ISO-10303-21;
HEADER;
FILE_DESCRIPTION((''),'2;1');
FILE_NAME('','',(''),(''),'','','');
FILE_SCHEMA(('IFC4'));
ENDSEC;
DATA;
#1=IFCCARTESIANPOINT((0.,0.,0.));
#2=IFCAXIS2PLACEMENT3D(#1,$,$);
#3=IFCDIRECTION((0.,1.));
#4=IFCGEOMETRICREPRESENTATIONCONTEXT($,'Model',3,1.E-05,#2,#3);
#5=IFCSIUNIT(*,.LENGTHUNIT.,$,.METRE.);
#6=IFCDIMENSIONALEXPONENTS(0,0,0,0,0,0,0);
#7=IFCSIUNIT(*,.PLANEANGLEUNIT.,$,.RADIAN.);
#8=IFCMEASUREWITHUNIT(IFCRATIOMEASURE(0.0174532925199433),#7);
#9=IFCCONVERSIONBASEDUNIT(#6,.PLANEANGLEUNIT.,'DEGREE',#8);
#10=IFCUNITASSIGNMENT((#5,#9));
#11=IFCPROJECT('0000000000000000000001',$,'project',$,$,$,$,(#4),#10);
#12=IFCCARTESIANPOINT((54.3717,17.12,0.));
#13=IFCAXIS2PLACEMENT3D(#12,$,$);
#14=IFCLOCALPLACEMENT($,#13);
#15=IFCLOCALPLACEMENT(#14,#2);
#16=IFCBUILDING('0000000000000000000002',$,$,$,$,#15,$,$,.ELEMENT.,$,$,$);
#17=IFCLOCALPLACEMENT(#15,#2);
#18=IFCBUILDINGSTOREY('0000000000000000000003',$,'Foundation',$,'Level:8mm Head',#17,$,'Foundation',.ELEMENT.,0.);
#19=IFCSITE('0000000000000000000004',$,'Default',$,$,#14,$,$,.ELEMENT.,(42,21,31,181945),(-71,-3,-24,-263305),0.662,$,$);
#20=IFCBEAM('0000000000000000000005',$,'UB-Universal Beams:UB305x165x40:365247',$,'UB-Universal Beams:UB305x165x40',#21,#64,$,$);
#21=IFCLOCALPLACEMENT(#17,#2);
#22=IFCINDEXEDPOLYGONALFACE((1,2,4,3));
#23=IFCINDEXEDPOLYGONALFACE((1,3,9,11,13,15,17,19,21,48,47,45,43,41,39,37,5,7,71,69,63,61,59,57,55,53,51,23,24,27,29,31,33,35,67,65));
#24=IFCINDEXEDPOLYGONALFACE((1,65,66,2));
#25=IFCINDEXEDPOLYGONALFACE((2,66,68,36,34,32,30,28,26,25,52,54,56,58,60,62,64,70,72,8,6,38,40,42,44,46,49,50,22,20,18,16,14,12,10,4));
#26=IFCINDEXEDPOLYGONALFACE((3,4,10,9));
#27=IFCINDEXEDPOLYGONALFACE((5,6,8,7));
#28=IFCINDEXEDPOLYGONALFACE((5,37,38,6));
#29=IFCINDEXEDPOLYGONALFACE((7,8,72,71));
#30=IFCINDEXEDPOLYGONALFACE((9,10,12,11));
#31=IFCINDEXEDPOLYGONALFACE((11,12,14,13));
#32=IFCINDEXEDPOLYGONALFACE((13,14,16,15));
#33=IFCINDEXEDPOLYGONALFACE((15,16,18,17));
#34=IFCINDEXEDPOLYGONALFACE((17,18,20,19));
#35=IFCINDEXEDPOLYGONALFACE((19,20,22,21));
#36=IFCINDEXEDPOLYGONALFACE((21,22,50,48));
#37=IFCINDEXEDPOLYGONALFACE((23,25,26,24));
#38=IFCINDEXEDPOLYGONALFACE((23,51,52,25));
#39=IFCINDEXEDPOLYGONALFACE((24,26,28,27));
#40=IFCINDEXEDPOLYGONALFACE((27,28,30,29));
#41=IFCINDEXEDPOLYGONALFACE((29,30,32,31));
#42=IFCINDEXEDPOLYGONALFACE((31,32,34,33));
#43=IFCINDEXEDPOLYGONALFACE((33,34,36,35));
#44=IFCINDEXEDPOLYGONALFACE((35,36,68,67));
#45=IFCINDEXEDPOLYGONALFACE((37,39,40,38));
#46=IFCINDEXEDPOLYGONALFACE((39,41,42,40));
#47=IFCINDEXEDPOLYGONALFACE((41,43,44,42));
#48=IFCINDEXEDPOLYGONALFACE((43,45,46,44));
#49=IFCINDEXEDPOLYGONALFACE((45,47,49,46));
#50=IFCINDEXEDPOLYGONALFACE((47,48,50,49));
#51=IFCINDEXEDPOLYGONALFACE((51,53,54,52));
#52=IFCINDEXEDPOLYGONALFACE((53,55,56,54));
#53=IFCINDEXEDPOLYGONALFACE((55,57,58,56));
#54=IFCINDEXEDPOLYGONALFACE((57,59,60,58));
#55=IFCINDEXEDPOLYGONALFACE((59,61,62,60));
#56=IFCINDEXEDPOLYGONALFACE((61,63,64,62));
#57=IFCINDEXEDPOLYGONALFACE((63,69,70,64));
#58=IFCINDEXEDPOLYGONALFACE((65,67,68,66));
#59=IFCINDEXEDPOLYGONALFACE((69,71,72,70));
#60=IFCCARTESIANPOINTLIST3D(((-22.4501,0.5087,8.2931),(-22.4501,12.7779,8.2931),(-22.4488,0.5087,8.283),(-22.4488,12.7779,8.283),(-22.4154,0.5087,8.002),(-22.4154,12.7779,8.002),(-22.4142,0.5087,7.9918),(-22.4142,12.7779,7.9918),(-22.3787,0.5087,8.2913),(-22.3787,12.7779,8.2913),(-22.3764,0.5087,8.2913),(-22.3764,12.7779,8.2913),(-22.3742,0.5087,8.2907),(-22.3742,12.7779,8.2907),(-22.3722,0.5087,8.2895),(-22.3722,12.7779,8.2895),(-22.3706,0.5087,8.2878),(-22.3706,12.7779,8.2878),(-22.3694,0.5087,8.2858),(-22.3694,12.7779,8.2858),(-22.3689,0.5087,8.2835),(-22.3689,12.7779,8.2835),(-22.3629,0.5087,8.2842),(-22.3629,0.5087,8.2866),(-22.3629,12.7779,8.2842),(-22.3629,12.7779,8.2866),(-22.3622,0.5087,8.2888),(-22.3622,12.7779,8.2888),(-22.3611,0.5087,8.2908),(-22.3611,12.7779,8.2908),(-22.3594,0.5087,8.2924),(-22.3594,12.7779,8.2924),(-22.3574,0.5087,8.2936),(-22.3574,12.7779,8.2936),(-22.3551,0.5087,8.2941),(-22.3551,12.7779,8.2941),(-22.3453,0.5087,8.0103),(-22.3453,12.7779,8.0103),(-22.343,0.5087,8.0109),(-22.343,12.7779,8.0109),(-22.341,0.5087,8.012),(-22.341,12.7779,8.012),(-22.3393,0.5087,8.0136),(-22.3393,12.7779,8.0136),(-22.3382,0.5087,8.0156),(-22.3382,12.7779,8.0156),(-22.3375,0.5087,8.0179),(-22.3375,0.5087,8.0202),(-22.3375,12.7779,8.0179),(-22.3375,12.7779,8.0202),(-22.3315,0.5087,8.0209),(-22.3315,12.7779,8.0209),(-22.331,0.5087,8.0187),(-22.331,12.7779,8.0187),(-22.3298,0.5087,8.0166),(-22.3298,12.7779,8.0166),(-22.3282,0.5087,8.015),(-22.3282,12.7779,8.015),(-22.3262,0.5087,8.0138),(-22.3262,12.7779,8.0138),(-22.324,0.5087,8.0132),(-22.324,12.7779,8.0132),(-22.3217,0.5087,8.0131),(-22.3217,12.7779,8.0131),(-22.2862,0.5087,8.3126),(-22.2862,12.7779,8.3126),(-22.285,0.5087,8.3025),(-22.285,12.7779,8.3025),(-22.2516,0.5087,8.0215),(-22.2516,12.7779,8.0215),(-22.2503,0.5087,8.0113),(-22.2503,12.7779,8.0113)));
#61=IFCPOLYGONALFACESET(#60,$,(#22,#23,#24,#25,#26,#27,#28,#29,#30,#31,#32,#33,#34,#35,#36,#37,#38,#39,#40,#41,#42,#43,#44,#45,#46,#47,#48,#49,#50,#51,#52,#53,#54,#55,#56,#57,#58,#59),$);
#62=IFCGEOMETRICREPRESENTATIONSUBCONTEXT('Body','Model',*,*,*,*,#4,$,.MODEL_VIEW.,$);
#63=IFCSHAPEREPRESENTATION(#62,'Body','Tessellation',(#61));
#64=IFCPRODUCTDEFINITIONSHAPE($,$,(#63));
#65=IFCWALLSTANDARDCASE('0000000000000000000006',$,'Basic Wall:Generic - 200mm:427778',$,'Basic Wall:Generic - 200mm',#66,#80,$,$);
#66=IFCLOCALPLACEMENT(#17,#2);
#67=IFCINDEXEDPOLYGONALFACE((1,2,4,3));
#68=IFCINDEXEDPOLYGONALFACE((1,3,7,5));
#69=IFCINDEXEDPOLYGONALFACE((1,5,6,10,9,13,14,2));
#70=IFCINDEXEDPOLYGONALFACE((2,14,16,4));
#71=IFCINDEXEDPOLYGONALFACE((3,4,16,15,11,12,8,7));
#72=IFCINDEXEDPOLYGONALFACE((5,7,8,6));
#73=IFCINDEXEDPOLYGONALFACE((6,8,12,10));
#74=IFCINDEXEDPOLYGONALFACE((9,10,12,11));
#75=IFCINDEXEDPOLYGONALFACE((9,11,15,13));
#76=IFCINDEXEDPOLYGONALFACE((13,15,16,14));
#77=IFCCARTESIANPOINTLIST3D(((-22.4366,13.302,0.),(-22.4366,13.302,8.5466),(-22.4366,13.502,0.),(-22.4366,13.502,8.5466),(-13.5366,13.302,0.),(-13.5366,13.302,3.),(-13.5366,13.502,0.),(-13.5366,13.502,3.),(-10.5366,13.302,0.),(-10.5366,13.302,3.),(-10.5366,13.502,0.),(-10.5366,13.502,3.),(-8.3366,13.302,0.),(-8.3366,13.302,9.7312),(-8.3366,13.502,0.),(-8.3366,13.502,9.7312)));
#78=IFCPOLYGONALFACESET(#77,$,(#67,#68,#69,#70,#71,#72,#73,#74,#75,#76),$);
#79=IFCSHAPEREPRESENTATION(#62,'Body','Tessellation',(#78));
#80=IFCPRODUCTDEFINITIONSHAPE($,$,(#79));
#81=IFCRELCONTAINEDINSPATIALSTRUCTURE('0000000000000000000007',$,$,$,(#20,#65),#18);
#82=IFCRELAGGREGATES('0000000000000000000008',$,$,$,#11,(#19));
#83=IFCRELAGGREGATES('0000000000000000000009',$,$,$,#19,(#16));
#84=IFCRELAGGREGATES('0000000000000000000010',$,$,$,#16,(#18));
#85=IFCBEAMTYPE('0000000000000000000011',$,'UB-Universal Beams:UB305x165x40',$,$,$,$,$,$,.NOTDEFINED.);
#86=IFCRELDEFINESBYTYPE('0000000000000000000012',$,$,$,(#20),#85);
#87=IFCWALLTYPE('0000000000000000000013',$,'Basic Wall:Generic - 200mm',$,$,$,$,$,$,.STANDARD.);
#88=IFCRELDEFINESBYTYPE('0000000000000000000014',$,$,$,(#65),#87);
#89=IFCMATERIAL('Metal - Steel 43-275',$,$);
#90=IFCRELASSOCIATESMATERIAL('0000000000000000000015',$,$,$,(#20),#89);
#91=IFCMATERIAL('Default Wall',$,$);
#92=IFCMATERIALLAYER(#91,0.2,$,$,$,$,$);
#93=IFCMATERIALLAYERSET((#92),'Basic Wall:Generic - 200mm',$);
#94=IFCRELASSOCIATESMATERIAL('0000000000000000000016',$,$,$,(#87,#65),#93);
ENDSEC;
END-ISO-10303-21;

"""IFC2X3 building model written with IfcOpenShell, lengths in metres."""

from ifc_helpers import new_model, entity, si_unit, converted_unit, direction, frame, frame_2d, origin, place, context, subcontext, project, spatial, polyline, circle_curve, parameter, trimmed, segment, composite_curve, rectangle, outline, extrude, clip, halfspace, material, layer, layer_set, layer_usage, type_object, element, save


model = new_model("IFC2X3")

# Units and contexts
model_context = context("Model", 3, precision=1e-05, world=origin(), true_north=direction((0.0, 1.0)))
body_context = subcontext(model_context, "Body", "Model", "MODEL_VIEW")
ifc_project = project(units=[si_unit("LENGTHUNIT", "METRE"), converted_unit("PLANEANGLEUNIT", "DEGREE", entity("IfcRatioMeasure", 0.0174532925199433), si_unit("PLANEANGLEUNIT", "RADIAN"), dimensions=[0, 0, 0, 0, 0, 0, 0])], contexts=[model_context])

# Site, building, storey
site_placement = place(None, frame((54.3717, 17.12, 0.0)))
site = spatial("IfcSite", under=ifc_project, at=site_placement, Name="Default", CompositionType="ELEMENT", RefLatitude=(42, 21, 31, 181945), RefLongitude=(-71, -3, -24, -263305), RefElevation=0.662)
building_placement = place(site_placement, origin())
building = spatial("IfcBuilding", under=site, at=building_placement, CompositionType="ELEMENT")
storey_placement = place(building_placement, origin())
storey = spatial("IfcBuildingStorey", under=building, at=storey_placement, Name="Foundation", ObjectType="Level:8mm Head", LongName="Foundation", CompositionType="ELEMENT", Elevation=0.0)

# Shared definitions
ifc_material_1 = material(Name="Metal - Steel 43-275")

# Beam
beam_type = type_object("IfcBeamType", Name="UB-Universal Beams:UB305x165x40", PredefinedType="NOTDEFINED")
beam_placement = place(storey_placement, frame((-22.3321, 12.9433, 8.0), z_axis=(0.0, 0.0, 1.0), x_axis=(0.0, -1.0, 0.0)))
element("IfcBeam", 1, at=beam_placement, inside=storey, type_object=beam_type, material=ifc_material_1, Name="UB-Universal Beams:UB305x165x40:365247", ObjectType="UB-Universal Beams:UB305x165x40", context=body_context, shape_type="SweptSolid", body=[
    extrude(outline(composite_curve([segment(polyline([(-0.0825, -0.1415), (-0.0825, -0.1517)]), True, "CONTINUOUS"), segment(polyline([(-0.0825, -0.1517), (0.0825, -0.1517)]), True, "CONTINUOUS"), segment(polyline([(0.0825, -0.1517), (0.0825, -0.1415)]), True, "CONTINUOUS"), segment(polyline([(0.0825, -0.1415), (0.0119, -0.1415)]), True, "CONTINUOUS"), segment(trimmed(circle_curve(frame_2d((0.0119, -0.1326), x_axis=(-1.0, 0.0)), 0.0089), [parameter(0.0)], [parameter(90.0)], True, "PARAMETER"), False, "CONTINUOUS"), segment(polyline([(0.003, -0.1326), (0.003, 0.1326)]), True, "CONTINUOUS"), segment(trimmed(circle_curve(frame_2d((0.0119, 0.1326), x_axis=(0.0, 1.0)), 0.0089), [parameter(0.0)], [parameter(90.0)], True, "PARAMETER"), False, "CONTINUOUS"), segment(polyline([(0.0119, 0.1415), (0.0825, 0.1415)]), True, "CONTINUOUS"), segment(polyline([(0.0825, 0.1415), (0.0825, 0.1517)]), True, "CONTINUOUS"), segment(polyline([(0.0825, 0.1517), (-0.0825, 0.1517)]), True, "CONTINUOUS"), segment(polyline([(-0.0825, 0.1517), (-0.0825, 0.1415)]), True, "CONTINUOUS"), segment(polyline([(-0.0825, 0.1415), (-0.0119, 0.1415)]), True, "CONTINUOUS"), segment(trimmed(circle_curve(frame_2d((-0.0119, 0.1326), x_axis=(1.0, 0.0)), 0.0089), [parameter(0.0)], [parameter(90.0)], True, "PARAMETER"), False, "CONTINUOUS"), segment(polyline([(-0.003, 0.1326), (-0.003, -0.1326)]), True, "CONTINUOUS"), segment(trimmed(circle_curve(frame_2d((-0.0119, -0.1326), x_axis=(0.0, -1.0)), 0.0089), [parameter(0.0)], [parameter(90.0)], True, "PARAMETER"), False, "CONTINUOUS"), segment(polyline([(-0.0119, -0.1415), (-0.0825, -0.1415)]), True, "CONTINUOUS")], self_intersect=False)), frame((0.1654, -0.0181, 0.1522), z_axis=(-1.0, 0.0, 0.0), x_axis=(0.0, -0.992988, -0.118213)), (0.0, 0.0, -1.0), 12.2692),
])

# Wall, opening
ifc_material_2 = material(Name="Default Wall")
ifc_layer = layer(ifc_material_2, 0.2)
ifc_layer_set = layer_set([ifc_layer], Name="Basic Wall:Generic - 200mm")
ifc_layer_usage = layer_usage(ifc_layer_set, "AXIS2", "NEGATIVE", 0.1)
wall_type = type_object("IfcWallType", Name="Basic Wall:Generic - 200mm", PredefinedType="STANDARD", material=ifc_layer_set)
wall_placement = place(storey_placement, frame((-22.4366, 13.402, 0.0)))
wall = element("IfcWallStandardCase", 2, at=wall_placement, inside=storey, type_object=wall_type, material=ifc_layer_usage, Name="Basic Wall:Generic - 200mm:427778", ObjectType="Basic Wall:Generic - 200mm", context=body_context, shape_type="Clipping", body=[
    clip(extrude(rectangle(XDim=14.1, YDim=0.2, at=frame_2d((7.05, 0.0), x_axis=(-1.0, 0.0))), origin(), (0.0, 0.0, 1.0), 9.7312), halfspace(frame((0.0, -0.1, 8.5466), z_axis=(-0.083718, 0.0, 0.99649), x_axis=(0.0, 1.0, 0.0)), False)),
])
opening_1_placement = place(wall_placement, origin())
element("IfcOpeningElement", 3, at=opening_1_placement, cuts=wall, ObjectType="Opening", context=body_context, shape_type="SweptSolid", body=[
    extrude(rectangle(XDim=3.0, YDim=3.0, at=frame_2d((0.0, 0.0), x_axis=(1.0, 0.0))), frame((10.4, 0.1, 1.5), z_axis=(0.0, -1.0, 0.0), x_axis=(0.0, 0.0, 1.0)), (0.0, 0.0, 1.0), 0.2),
])

save(model, "model.ifc")
